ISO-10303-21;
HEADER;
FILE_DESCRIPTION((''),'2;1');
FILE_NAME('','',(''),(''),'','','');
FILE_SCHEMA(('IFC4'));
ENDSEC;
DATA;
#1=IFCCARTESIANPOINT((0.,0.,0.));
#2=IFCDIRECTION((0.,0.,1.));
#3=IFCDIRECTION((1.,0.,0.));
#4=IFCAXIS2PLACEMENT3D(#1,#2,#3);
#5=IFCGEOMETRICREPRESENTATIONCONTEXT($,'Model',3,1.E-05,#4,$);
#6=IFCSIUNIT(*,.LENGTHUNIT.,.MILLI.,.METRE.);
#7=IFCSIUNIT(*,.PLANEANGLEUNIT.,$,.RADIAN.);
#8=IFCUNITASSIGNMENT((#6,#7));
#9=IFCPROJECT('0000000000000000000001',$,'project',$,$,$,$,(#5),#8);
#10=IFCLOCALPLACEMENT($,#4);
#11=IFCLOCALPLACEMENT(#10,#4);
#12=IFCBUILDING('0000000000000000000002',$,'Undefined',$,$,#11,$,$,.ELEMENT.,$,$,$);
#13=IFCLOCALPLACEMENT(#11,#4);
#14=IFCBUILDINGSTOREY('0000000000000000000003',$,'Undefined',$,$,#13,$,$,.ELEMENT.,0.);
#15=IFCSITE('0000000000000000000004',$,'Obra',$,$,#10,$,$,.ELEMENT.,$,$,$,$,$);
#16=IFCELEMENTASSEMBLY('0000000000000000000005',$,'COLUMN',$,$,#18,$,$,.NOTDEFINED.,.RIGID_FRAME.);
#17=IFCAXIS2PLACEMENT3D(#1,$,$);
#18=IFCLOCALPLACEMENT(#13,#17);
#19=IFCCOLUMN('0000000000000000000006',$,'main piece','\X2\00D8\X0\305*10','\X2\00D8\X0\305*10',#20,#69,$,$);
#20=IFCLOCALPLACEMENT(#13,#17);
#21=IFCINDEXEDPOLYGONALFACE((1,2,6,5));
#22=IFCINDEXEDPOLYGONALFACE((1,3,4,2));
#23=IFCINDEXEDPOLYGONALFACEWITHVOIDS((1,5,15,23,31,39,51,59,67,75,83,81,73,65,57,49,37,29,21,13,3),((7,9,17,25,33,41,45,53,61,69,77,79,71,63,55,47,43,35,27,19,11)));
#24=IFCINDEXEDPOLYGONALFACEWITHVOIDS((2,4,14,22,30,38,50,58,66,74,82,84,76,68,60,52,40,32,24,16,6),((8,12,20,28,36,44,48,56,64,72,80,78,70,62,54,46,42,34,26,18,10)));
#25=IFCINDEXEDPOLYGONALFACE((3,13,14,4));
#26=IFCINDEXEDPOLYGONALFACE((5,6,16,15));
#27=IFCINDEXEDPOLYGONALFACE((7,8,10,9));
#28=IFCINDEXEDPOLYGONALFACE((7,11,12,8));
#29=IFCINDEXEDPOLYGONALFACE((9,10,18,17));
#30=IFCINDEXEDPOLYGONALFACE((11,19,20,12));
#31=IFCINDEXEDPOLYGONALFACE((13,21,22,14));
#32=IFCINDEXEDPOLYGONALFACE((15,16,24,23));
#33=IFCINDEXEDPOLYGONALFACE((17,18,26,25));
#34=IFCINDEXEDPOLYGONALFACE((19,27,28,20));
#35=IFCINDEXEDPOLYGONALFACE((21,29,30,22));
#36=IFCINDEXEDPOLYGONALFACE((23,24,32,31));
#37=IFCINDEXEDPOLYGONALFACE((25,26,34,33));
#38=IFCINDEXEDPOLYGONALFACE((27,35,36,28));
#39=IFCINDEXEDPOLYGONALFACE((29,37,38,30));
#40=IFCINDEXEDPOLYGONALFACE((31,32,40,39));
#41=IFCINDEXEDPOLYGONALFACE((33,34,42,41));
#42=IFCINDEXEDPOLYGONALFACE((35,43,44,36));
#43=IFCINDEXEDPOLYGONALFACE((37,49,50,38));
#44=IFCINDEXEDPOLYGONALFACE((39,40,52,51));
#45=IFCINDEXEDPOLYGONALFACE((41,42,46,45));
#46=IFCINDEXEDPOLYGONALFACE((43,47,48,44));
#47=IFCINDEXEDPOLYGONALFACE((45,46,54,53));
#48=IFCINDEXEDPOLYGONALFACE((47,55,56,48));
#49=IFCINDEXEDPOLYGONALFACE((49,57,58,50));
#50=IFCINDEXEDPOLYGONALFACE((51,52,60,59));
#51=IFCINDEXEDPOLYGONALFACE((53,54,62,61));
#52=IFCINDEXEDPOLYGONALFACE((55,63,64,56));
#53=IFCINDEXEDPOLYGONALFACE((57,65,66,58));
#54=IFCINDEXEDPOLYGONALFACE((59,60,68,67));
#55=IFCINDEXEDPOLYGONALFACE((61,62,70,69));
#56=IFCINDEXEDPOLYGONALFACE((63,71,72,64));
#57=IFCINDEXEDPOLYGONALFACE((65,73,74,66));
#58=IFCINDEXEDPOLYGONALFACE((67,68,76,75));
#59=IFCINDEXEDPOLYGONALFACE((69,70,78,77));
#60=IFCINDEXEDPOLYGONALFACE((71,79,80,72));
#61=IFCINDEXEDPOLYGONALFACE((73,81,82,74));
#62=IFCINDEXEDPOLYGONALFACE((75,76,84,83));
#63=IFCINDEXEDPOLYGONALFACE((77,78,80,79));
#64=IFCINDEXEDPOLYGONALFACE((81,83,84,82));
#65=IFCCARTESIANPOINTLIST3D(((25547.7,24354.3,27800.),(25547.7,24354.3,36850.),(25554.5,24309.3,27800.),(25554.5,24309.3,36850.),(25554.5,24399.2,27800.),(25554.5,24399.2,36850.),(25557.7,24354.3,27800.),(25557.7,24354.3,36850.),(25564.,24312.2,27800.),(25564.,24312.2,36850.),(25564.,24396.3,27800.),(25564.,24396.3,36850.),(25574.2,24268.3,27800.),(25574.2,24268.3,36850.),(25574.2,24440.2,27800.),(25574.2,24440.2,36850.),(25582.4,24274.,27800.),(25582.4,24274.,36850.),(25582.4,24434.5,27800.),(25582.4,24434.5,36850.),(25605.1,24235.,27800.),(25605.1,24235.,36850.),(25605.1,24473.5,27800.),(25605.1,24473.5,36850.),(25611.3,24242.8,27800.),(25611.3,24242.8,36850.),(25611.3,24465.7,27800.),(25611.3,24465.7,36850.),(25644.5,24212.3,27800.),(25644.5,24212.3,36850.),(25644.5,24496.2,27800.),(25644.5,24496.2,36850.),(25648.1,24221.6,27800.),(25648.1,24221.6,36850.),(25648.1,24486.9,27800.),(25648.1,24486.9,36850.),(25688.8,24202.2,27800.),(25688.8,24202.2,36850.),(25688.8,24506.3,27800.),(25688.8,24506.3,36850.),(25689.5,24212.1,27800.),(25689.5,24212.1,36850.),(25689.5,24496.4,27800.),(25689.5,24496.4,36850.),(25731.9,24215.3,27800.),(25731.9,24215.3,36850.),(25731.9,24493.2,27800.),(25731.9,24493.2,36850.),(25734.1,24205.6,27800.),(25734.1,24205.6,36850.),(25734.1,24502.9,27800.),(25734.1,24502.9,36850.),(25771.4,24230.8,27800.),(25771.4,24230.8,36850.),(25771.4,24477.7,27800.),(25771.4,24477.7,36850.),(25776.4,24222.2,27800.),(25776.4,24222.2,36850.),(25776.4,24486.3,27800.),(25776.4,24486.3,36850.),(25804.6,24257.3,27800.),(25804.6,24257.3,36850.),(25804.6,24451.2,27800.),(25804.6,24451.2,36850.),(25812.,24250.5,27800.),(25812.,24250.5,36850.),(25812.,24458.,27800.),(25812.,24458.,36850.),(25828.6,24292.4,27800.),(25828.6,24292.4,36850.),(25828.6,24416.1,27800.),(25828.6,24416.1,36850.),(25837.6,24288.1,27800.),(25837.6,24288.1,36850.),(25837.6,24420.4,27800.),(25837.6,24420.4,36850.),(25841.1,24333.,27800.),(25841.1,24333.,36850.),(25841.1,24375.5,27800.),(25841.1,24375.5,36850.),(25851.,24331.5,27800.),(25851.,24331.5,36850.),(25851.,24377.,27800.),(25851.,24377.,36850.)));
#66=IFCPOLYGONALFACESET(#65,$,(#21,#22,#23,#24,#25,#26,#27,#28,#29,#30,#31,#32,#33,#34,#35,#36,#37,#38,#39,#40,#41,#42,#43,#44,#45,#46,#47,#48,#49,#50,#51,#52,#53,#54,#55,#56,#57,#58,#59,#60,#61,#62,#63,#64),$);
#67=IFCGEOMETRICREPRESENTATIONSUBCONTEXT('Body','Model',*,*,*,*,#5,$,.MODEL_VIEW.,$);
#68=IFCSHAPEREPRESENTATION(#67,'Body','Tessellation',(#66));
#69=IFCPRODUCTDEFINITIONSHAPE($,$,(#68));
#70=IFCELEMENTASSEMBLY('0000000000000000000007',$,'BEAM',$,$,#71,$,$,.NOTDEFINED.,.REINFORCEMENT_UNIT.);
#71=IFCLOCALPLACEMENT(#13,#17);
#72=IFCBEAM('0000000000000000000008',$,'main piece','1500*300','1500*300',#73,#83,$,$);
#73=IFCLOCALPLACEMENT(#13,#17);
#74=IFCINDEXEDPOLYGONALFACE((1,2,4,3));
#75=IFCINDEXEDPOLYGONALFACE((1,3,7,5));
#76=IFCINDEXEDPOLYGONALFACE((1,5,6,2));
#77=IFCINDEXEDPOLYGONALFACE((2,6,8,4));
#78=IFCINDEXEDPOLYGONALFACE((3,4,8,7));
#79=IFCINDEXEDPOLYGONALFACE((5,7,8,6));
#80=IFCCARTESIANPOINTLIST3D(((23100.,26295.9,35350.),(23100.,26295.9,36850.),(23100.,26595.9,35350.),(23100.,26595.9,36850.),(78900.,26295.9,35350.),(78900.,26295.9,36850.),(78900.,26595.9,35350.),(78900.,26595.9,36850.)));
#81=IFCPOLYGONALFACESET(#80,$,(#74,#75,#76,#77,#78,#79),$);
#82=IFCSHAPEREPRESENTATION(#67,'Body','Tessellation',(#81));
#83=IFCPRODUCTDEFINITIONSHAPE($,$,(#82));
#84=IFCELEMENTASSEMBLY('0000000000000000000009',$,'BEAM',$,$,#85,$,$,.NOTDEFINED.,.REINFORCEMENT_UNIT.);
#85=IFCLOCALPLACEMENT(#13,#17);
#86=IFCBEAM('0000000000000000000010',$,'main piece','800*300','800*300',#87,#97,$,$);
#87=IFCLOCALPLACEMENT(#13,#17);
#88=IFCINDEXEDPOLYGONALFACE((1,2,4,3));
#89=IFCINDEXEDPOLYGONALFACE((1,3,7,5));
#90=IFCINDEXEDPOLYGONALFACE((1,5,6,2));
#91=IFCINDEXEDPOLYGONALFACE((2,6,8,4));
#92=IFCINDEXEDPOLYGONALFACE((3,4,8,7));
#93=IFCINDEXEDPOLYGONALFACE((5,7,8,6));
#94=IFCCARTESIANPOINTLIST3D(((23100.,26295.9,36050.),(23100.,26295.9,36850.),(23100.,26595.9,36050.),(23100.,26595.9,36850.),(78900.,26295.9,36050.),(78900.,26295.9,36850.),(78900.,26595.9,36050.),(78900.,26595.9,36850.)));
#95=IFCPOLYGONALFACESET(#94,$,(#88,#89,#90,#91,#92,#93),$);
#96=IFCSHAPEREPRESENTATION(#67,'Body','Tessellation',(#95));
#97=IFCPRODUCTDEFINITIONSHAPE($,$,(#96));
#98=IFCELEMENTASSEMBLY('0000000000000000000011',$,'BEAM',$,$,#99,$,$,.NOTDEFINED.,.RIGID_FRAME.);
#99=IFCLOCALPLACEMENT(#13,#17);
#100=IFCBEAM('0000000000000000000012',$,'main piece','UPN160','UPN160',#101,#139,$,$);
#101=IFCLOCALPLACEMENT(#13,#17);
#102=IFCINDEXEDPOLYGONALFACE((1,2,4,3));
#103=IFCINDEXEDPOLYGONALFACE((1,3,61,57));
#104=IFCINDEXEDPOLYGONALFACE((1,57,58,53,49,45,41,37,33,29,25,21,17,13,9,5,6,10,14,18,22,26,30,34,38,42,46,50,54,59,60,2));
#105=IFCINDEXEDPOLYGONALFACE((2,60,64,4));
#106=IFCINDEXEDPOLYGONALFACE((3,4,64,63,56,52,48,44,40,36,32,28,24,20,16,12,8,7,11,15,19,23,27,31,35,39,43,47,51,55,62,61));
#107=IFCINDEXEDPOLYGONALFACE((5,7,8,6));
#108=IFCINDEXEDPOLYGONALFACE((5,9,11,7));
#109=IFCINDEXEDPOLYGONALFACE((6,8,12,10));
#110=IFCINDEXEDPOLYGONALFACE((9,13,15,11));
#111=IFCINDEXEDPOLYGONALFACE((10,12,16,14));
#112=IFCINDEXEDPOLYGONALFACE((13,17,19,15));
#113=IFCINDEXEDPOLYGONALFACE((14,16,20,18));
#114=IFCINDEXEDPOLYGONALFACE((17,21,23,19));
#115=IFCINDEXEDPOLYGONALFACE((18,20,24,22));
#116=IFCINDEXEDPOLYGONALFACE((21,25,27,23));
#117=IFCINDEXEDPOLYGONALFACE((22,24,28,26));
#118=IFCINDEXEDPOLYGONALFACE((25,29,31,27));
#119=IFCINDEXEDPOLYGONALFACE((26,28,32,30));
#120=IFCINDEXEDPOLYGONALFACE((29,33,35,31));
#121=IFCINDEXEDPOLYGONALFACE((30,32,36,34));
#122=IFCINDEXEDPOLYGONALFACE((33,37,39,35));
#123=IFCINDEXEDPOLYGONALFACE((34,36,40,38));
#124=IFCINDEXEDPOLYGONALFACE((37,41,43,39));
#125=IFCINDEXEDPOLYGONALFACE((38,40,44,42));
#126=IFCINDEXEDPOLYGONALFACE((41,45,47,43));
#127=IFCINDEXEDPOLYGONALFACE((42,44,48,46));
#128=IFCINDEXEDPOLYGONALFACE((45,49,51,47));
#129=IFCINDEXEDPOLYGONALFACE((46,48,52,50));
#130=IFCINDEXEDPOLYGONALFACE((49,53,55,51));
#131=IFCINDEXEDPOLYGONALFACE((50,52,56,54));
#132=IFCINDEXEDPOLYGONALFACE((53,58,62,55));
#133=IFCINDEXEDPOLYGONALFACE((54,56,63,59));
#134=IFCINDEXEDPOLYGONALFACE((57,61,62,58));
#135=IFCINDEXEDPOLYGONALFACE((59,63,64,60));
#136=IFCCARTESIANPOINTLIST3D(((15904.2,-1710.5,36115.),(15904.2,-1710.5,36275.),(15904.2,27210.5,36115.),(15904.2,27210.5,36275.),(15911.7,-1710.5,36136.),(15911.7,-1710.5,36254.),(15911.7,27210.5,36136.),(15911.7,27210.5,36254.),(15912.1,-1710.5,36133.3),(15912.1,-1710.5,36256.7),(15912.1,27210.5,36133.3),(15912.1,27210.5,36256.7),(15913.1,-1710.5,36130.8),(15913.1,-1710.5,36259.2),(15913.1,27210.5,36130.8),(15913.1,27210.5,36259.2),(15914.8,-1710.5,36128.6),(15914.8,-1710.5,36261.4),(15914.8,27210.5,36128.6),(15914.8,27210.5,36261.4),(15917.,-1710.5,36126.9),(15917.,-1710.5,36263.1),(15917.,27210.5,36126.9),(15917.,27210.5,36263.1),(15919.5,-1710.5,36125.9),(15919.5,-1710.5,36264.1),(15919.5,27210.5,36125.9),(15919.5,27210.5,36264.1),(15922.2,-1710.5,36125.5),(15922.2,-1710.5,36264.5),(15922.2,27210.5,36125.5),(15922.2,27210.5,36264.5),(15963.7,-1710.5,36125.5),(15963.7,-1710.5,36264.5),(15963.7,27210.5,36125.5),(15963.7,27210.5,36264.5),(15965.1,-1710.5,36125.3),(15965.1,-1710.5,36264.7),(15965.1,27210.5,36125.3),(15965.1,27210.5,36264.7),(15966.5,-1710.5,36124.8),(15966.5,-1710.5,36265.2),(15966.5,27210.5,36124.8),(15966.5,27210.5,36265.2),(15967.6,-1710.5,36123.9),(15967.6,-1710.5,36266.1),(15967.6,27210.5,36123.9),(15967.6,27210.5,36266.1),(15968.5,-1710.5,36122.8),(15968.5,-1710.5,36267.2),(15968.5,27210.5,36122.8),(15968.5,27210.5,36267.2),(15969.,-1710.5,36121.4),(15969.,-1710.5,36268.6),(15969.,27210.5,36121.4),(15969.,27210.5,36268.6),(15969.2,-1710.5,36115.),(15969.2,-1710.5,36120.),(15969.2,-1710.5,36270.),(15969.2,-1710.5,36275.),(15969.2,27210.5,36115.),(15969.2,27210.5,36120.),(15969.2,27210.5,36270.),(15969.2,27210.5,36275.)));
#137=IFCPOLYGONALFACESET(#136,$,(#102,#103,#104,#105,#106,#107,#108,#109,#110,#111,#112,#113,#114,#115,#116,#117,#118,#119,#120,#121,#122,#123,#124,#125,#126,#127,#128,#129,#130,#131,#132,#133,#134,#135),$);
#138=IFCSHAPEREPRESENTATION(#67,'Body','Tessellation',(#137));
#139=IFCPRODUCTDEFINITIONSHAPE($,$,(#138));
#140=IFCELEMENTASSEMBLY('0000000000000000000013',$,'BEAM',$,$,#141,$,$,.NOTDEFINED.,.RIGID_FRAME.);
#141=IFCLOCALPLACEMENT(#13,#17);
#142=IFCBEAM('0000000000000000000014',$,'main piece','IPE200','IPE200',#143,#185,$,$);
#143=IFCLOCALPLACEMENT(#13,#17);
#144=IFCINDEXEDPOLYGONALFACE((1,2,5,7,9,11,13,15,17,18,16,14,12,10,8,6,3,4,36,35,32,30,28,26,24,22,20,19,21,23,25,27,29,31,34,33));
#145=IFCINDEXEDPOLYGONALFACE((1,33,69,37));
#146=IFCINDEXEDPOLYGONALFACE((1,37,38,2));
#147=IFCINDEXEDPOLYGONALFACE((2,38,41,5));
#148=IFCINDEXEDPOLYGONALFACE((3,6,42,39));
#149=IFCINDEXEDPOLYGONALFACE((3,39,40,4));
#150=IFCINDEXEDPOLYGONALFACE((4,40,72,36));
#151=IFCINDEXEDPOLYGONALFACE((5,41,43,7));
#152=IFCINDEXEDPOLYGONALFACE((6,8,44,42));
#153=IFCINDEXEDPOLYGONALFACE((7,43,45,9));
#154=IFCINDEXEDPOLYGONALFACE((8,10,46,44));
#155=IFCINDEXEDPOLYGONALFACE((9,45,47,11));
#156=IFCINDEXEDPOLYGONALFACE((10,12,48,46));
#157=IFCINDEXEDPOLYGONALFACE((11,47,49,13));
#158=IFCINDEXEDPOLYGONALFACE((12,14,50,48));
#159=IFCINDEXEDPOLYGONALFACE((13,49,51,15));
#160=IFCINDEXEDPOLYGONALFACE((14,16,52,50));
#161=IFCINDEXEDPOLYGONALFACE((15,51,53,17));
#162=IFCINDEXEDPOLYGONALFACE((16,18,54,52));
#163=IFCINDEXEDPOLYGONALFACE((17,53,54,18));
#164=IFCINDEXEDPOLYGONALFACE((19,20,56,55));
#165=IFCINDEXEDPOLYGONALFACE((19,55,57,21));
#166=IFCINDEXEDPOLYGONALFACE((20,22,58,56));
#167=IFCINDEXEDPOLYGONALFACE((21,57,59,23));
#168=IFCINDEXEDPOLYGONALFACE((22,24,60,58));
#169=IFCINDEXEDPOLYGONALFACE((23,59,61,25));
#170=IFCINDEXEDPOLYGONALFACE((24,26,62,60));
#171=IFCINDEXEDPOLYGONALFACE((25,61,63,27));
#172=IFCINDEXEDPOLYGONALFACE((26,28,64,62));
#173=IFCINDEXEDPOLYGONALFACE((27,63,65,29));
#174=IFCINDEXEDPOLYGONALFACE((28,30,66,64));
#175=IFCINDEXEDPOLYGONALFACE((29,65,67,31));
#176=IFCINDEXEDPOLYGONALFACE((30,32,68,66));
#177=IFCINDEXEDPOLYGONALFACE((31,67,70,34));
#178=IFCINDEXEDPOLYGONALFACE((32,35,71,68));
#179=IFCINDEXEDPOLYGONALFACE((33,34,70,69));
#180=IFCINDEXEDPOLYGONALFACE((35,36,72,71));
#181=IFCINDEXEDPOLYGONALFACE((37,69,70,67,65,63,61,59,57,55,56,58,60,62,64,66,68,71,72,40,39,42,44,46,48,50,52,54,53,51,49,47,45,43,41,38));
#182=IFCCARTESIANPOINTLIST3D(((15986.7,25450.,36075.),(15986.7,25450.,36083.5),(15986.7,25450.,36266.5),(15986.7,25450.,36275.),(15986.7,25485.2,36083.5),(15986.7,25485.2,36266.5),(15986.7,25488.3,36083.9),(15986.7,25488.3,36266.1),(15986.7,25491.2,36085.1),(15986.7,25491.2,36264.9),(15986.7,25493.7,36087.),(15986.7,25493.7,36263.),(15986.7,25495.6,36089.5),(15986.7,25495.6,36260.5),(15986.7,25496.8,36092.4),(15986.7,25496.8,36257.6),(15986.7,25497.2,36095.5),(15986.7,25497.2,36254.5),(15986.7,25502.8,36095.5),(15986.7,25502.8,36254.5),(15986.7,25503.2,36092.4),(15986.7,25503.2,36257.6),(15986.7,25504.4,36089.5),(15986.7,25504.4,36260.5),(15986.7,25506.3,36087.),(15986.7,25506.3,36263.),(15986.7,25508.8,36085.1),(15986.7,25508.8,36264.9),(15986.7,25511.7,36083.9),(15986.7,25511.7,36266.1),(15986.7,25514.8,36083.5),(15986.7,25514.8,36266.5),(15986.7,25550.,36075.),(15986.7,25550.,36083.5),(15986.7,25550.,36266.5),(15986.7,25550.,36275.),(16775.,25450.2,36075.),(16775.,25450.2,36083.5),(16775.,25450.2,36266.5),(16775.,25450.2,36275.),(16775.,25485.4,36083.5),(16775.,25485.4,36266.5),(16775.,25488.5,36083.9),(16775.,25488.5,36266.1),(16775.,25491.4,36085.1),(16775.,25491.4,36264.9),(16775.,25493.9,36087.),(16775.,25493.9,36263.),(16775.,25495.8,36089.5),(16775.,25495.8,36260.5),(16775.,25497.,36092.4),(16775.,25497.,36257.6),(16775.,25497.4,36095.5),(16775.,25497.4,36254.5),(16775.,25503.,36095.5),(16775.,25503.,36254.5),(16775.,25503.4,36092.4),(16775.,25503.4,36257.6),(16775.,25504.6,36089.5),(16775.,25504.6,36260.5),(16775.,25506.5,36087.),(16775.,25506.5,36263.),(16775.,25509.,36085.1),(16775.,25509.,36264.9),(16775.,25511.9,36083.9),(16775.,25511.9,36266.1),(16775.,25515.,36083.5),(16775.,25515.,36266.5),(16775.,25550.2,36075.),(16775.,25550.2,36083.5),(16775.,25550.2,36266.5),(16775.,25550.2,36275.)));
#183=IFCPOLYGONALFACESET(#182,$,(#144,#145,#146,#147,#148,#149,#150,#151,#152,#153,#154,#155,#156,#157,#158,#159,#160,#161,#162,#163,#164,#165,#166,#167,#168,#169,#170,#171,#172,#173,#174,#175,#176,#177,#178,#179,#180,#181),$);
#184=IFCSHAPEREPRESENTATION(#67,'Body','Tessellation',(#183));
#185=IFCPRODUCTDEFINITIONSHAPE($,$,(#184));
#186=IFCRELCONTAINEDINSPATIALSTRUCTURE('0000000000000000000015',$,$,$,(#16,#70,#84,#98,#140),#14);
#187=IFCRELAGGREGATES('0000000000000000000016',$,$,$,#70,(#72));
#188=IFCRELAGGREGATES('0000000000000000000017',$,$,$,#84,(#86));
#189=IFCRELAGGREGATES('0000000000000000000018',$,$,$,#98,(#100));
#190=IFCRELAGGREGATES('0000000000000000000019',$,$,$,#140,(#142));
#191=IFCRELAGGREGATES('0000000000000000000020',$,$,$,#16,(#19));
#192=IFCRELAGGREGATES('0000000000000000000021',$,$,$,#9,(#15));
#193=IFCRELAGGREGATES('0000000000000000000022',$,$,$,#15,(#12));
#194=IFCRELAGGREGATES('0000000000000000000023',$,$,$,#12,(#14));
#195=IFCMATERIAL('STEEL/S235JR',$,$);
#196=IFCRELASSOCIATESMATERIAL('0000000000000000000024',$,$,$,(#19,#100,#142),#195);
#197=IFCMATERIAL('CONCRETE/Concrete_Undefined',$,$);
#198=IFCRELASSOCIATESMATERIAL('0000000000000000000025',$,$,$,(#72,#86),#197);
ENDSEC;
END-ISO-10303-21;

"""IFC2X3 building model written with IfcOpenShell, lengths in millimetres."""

from ifc_helpers import new_model, si_unit, frame, origin_with_axes, origin_2d_with_axis, place, context, subcontext, project, spatial, rectangle, hollow_circle, i_section, u_section, extrude, material, element, aggregate, save


model = new_model("IFC2X3")

# Units and contexts
model_context = context("Model", 3, precision=1e-05, world=origin_with_axes())
body_context = subcontext(model_context, "Body", "Model", "MODEL_VIEW")
ifc_project = project(units=[si_unit("LENGTHUNIT", "METRE", prefix="MILLI"), si_unit("PLANEANGLEUNIT", "RADIAN")], contexts=[model_context])

# Site, building, storey
site_placement = place(None, origin_with_axes())
site = spatial("IfcSite", under=ifc_project, at=site_placement, Name="Obra", CompositionType="ELEMENT")
building_placement = place(site_placement, origin_with_axes())
building = spatial("IfcBuilding", under=site, at=building_placement, Name="Undefined", CompositionType="ELEMENT")
storey_placement = place(building_placement, origin_with_axes())
storey = spatial("IfcBuildingStorey", under=building, at=storey_placement, Name="Undefined", CompositionType="ELEMENT", Elevation=0.0)

# Element assembly, column
ifc_material_1 = material(Name="STEEL/S235JR")
assembly_1_placement = place(storey_placement, origin_with_axes())
assembly_1 = element("IfcElementAssembly", 1, at=assembly_1_placement, inside=storey, Name="COLUMN", AssemblyPlace="NOTDEFINED", PredefinedType="RIGID_FRAME")
column_1_placement = place(assembly_1_placement, frame((25700.2, 24354.3, 27800.0), z_axis=(0.0, 0.0, 1.0), x_axis=(0.0, 1.0, 0.0)))
column_1 = element("IfcColumn", 2, at=column_1_placement, material=ifc_material_1, Name="main piece", Description="Ø305*10", ObjectType="Ø305*10", context=body_context, shape_type="SweptSolid", body=[
    extrude(hollow_circle(Radius=152.5, WallThickness=10.0, at=origin_2d_with_axis()), frame((0.0, 0.0, 9050.0), z_axis=(0.0, 0.0, -1.0), x_axis=(0.0, 1.0, 0.0)), (0.0, 0.0, 1.0), 9050.0),
])

# Element assemblies, beams
assembly_2_placement = place(storey_placement, origin_with_axes())
assembly_2 = element("IfcElementAssembly", 3, at=assembly_2_placement, inside=storey, Name="BEAM", AssemblyPlace="NOTDEFINED", PredefinedType="REINFORCEMENT_UNIT")
ifc_material_2 = material(Name="CONCRETE/Concrete_Undefined")
beam_1_placement = place(assembly_2_placement, frame((23100.0, 26445.9, 36100.0), z_axis=(0.0, 0.0, 1.0), x_axis=(1.0, 0.0, 0.0)))
beam_1 = element("IfcBeam", 4, at=beam_1_placement, material=ifc_material_2, Name="main piece", Description="1500*300", ObjectType="1500*300", context=body_context, shape_type="SweptSolid", body=[
    extrude(rectangle(XDim=300.0, YDim=1500.0, at=origin_2d_with_axis()), frame((55800.0, 0.0, 0.0), z_axis=(-1.0, 0.0, 0.0), x_axis=(0.0, -1.0, 0.0)), (0.0, 0.0, 1.0), 55800.0),
])
aggregate(assembly_2, [beam_1])
assembly_3_placement = place(storey_placement, origin_with_axes())
assembly_3 = element("IfcElementAssembly", 5, at=assembly_3_placement, inside=storey, Name="BEAM", AssemblyPlace="NOTDEFINED", PredefinedType="REINFORCEMENT_UNIT")
beam_2_placement = place(assembly_3_placement, frame((23100.0, 26445.9, 36450.0), z_axis=(0.0, 0.0, 1.0), x_axis=(1.0, 0.0, 0.0)))
beam_2 = element("IfcBeam", 6, at=beam_2_placement, material=ifc_material_2, Name="main piece", Description="800*300", ObjectType="800*300", context=body_context, shape_type="SweptSolid", body=[
    extrude(rectangle(XDim=300.0, YDim=800.0, at=origin_2d_with_axis()), frame((55800.0, 0.0, 0.0), z_axis=(-1.0, 0.0, 0.0), x_axis=(0.0, -1.0, 0.0)), (0.0, 0.0, 1.0), 55800.0),
])
aggregate(assembly_3, [beam_2])
assembly_4_placement = place(storey_placement, origin_with_axes())
assembly_4 = element("IfcElementAssembly", 7, at=assembly_4_placement, inside=storey, Name="BEAM", AssemblyPlace="NOTDEFINED", PredefinedType="RIGID_FRAME")
beam_3_placement = place(assembly_4_placement, frame((15936.7, 27210.5, 36195.0), z_axis=(0.0, 0.0, -1.0), x_axis=(0.0, -1.0, 0.0)))
beam_3 = element("IfcBeam", 8, at=beam_3_placement, material=ifc_material_1, Name="main piece", Description="UPN160", ObjectType="UPN160", context=body_context, shape_type="SweptSolid", body=[
    extrude(u_section(Depth=160.0, FlangeWidth=65.0, WebThickness=7.5, FlangeThickness=10.5, FilletRadius=10.5, EdgeRadius=5.5, at=origin_2d_with_axis()), frame((28921.0, 0.0, 0.0), z_axis=(-1.0, 0.0, 0.0), x_axis=(0.0, -1.0, 0.0)), (0.0, 0.0, 1.0), 28921.0),
])
aggregate(assembly_4, [beam_3])
assembly_5_placement = place(storey_placement, origin_with_axes())
assembly_5 = element("IfcElementAssembly", 9, at=assembly_5_placement, inside=storey, Name="BEAM", AssemblyPlace="NOTDEFINED", PredefinedType="RIGID_FRAME")
beam_4_placement = place(assembly_5_placement, frame((16775.0, 25500.2, 36175.0), z_axis=(0.0, 0.0, 1.0), x_axis=(-1.0, -0.000266, 0.0)))
beam_4 = element("IfcBeam", 10, at=beam_4_placement, material=ifc_material_1, Name="main piece", Description="IPE200", ObjectType="IPE200", context=body_context, shape_type="SweptSolid", body=[
    extrude(i_section(OverallWidth=100.0, OverallDepth=200.0, WebThickness=5.6, FlangeThickness=8.5, FilletRadius=12.0, at=origin_2d_with_axis()), frame((788.3, 0.0, 0.0), z_axis=(-1.0, 0.0, 0.0), x_axis=(0.0, -1.0, 0.0)), (0.0, 0.0, 1.0), 788.3),
])
aggregate(assembly_5, [beam_4])

aggregate(assembly_1, [column_1])

save(model, "model.ifc")
